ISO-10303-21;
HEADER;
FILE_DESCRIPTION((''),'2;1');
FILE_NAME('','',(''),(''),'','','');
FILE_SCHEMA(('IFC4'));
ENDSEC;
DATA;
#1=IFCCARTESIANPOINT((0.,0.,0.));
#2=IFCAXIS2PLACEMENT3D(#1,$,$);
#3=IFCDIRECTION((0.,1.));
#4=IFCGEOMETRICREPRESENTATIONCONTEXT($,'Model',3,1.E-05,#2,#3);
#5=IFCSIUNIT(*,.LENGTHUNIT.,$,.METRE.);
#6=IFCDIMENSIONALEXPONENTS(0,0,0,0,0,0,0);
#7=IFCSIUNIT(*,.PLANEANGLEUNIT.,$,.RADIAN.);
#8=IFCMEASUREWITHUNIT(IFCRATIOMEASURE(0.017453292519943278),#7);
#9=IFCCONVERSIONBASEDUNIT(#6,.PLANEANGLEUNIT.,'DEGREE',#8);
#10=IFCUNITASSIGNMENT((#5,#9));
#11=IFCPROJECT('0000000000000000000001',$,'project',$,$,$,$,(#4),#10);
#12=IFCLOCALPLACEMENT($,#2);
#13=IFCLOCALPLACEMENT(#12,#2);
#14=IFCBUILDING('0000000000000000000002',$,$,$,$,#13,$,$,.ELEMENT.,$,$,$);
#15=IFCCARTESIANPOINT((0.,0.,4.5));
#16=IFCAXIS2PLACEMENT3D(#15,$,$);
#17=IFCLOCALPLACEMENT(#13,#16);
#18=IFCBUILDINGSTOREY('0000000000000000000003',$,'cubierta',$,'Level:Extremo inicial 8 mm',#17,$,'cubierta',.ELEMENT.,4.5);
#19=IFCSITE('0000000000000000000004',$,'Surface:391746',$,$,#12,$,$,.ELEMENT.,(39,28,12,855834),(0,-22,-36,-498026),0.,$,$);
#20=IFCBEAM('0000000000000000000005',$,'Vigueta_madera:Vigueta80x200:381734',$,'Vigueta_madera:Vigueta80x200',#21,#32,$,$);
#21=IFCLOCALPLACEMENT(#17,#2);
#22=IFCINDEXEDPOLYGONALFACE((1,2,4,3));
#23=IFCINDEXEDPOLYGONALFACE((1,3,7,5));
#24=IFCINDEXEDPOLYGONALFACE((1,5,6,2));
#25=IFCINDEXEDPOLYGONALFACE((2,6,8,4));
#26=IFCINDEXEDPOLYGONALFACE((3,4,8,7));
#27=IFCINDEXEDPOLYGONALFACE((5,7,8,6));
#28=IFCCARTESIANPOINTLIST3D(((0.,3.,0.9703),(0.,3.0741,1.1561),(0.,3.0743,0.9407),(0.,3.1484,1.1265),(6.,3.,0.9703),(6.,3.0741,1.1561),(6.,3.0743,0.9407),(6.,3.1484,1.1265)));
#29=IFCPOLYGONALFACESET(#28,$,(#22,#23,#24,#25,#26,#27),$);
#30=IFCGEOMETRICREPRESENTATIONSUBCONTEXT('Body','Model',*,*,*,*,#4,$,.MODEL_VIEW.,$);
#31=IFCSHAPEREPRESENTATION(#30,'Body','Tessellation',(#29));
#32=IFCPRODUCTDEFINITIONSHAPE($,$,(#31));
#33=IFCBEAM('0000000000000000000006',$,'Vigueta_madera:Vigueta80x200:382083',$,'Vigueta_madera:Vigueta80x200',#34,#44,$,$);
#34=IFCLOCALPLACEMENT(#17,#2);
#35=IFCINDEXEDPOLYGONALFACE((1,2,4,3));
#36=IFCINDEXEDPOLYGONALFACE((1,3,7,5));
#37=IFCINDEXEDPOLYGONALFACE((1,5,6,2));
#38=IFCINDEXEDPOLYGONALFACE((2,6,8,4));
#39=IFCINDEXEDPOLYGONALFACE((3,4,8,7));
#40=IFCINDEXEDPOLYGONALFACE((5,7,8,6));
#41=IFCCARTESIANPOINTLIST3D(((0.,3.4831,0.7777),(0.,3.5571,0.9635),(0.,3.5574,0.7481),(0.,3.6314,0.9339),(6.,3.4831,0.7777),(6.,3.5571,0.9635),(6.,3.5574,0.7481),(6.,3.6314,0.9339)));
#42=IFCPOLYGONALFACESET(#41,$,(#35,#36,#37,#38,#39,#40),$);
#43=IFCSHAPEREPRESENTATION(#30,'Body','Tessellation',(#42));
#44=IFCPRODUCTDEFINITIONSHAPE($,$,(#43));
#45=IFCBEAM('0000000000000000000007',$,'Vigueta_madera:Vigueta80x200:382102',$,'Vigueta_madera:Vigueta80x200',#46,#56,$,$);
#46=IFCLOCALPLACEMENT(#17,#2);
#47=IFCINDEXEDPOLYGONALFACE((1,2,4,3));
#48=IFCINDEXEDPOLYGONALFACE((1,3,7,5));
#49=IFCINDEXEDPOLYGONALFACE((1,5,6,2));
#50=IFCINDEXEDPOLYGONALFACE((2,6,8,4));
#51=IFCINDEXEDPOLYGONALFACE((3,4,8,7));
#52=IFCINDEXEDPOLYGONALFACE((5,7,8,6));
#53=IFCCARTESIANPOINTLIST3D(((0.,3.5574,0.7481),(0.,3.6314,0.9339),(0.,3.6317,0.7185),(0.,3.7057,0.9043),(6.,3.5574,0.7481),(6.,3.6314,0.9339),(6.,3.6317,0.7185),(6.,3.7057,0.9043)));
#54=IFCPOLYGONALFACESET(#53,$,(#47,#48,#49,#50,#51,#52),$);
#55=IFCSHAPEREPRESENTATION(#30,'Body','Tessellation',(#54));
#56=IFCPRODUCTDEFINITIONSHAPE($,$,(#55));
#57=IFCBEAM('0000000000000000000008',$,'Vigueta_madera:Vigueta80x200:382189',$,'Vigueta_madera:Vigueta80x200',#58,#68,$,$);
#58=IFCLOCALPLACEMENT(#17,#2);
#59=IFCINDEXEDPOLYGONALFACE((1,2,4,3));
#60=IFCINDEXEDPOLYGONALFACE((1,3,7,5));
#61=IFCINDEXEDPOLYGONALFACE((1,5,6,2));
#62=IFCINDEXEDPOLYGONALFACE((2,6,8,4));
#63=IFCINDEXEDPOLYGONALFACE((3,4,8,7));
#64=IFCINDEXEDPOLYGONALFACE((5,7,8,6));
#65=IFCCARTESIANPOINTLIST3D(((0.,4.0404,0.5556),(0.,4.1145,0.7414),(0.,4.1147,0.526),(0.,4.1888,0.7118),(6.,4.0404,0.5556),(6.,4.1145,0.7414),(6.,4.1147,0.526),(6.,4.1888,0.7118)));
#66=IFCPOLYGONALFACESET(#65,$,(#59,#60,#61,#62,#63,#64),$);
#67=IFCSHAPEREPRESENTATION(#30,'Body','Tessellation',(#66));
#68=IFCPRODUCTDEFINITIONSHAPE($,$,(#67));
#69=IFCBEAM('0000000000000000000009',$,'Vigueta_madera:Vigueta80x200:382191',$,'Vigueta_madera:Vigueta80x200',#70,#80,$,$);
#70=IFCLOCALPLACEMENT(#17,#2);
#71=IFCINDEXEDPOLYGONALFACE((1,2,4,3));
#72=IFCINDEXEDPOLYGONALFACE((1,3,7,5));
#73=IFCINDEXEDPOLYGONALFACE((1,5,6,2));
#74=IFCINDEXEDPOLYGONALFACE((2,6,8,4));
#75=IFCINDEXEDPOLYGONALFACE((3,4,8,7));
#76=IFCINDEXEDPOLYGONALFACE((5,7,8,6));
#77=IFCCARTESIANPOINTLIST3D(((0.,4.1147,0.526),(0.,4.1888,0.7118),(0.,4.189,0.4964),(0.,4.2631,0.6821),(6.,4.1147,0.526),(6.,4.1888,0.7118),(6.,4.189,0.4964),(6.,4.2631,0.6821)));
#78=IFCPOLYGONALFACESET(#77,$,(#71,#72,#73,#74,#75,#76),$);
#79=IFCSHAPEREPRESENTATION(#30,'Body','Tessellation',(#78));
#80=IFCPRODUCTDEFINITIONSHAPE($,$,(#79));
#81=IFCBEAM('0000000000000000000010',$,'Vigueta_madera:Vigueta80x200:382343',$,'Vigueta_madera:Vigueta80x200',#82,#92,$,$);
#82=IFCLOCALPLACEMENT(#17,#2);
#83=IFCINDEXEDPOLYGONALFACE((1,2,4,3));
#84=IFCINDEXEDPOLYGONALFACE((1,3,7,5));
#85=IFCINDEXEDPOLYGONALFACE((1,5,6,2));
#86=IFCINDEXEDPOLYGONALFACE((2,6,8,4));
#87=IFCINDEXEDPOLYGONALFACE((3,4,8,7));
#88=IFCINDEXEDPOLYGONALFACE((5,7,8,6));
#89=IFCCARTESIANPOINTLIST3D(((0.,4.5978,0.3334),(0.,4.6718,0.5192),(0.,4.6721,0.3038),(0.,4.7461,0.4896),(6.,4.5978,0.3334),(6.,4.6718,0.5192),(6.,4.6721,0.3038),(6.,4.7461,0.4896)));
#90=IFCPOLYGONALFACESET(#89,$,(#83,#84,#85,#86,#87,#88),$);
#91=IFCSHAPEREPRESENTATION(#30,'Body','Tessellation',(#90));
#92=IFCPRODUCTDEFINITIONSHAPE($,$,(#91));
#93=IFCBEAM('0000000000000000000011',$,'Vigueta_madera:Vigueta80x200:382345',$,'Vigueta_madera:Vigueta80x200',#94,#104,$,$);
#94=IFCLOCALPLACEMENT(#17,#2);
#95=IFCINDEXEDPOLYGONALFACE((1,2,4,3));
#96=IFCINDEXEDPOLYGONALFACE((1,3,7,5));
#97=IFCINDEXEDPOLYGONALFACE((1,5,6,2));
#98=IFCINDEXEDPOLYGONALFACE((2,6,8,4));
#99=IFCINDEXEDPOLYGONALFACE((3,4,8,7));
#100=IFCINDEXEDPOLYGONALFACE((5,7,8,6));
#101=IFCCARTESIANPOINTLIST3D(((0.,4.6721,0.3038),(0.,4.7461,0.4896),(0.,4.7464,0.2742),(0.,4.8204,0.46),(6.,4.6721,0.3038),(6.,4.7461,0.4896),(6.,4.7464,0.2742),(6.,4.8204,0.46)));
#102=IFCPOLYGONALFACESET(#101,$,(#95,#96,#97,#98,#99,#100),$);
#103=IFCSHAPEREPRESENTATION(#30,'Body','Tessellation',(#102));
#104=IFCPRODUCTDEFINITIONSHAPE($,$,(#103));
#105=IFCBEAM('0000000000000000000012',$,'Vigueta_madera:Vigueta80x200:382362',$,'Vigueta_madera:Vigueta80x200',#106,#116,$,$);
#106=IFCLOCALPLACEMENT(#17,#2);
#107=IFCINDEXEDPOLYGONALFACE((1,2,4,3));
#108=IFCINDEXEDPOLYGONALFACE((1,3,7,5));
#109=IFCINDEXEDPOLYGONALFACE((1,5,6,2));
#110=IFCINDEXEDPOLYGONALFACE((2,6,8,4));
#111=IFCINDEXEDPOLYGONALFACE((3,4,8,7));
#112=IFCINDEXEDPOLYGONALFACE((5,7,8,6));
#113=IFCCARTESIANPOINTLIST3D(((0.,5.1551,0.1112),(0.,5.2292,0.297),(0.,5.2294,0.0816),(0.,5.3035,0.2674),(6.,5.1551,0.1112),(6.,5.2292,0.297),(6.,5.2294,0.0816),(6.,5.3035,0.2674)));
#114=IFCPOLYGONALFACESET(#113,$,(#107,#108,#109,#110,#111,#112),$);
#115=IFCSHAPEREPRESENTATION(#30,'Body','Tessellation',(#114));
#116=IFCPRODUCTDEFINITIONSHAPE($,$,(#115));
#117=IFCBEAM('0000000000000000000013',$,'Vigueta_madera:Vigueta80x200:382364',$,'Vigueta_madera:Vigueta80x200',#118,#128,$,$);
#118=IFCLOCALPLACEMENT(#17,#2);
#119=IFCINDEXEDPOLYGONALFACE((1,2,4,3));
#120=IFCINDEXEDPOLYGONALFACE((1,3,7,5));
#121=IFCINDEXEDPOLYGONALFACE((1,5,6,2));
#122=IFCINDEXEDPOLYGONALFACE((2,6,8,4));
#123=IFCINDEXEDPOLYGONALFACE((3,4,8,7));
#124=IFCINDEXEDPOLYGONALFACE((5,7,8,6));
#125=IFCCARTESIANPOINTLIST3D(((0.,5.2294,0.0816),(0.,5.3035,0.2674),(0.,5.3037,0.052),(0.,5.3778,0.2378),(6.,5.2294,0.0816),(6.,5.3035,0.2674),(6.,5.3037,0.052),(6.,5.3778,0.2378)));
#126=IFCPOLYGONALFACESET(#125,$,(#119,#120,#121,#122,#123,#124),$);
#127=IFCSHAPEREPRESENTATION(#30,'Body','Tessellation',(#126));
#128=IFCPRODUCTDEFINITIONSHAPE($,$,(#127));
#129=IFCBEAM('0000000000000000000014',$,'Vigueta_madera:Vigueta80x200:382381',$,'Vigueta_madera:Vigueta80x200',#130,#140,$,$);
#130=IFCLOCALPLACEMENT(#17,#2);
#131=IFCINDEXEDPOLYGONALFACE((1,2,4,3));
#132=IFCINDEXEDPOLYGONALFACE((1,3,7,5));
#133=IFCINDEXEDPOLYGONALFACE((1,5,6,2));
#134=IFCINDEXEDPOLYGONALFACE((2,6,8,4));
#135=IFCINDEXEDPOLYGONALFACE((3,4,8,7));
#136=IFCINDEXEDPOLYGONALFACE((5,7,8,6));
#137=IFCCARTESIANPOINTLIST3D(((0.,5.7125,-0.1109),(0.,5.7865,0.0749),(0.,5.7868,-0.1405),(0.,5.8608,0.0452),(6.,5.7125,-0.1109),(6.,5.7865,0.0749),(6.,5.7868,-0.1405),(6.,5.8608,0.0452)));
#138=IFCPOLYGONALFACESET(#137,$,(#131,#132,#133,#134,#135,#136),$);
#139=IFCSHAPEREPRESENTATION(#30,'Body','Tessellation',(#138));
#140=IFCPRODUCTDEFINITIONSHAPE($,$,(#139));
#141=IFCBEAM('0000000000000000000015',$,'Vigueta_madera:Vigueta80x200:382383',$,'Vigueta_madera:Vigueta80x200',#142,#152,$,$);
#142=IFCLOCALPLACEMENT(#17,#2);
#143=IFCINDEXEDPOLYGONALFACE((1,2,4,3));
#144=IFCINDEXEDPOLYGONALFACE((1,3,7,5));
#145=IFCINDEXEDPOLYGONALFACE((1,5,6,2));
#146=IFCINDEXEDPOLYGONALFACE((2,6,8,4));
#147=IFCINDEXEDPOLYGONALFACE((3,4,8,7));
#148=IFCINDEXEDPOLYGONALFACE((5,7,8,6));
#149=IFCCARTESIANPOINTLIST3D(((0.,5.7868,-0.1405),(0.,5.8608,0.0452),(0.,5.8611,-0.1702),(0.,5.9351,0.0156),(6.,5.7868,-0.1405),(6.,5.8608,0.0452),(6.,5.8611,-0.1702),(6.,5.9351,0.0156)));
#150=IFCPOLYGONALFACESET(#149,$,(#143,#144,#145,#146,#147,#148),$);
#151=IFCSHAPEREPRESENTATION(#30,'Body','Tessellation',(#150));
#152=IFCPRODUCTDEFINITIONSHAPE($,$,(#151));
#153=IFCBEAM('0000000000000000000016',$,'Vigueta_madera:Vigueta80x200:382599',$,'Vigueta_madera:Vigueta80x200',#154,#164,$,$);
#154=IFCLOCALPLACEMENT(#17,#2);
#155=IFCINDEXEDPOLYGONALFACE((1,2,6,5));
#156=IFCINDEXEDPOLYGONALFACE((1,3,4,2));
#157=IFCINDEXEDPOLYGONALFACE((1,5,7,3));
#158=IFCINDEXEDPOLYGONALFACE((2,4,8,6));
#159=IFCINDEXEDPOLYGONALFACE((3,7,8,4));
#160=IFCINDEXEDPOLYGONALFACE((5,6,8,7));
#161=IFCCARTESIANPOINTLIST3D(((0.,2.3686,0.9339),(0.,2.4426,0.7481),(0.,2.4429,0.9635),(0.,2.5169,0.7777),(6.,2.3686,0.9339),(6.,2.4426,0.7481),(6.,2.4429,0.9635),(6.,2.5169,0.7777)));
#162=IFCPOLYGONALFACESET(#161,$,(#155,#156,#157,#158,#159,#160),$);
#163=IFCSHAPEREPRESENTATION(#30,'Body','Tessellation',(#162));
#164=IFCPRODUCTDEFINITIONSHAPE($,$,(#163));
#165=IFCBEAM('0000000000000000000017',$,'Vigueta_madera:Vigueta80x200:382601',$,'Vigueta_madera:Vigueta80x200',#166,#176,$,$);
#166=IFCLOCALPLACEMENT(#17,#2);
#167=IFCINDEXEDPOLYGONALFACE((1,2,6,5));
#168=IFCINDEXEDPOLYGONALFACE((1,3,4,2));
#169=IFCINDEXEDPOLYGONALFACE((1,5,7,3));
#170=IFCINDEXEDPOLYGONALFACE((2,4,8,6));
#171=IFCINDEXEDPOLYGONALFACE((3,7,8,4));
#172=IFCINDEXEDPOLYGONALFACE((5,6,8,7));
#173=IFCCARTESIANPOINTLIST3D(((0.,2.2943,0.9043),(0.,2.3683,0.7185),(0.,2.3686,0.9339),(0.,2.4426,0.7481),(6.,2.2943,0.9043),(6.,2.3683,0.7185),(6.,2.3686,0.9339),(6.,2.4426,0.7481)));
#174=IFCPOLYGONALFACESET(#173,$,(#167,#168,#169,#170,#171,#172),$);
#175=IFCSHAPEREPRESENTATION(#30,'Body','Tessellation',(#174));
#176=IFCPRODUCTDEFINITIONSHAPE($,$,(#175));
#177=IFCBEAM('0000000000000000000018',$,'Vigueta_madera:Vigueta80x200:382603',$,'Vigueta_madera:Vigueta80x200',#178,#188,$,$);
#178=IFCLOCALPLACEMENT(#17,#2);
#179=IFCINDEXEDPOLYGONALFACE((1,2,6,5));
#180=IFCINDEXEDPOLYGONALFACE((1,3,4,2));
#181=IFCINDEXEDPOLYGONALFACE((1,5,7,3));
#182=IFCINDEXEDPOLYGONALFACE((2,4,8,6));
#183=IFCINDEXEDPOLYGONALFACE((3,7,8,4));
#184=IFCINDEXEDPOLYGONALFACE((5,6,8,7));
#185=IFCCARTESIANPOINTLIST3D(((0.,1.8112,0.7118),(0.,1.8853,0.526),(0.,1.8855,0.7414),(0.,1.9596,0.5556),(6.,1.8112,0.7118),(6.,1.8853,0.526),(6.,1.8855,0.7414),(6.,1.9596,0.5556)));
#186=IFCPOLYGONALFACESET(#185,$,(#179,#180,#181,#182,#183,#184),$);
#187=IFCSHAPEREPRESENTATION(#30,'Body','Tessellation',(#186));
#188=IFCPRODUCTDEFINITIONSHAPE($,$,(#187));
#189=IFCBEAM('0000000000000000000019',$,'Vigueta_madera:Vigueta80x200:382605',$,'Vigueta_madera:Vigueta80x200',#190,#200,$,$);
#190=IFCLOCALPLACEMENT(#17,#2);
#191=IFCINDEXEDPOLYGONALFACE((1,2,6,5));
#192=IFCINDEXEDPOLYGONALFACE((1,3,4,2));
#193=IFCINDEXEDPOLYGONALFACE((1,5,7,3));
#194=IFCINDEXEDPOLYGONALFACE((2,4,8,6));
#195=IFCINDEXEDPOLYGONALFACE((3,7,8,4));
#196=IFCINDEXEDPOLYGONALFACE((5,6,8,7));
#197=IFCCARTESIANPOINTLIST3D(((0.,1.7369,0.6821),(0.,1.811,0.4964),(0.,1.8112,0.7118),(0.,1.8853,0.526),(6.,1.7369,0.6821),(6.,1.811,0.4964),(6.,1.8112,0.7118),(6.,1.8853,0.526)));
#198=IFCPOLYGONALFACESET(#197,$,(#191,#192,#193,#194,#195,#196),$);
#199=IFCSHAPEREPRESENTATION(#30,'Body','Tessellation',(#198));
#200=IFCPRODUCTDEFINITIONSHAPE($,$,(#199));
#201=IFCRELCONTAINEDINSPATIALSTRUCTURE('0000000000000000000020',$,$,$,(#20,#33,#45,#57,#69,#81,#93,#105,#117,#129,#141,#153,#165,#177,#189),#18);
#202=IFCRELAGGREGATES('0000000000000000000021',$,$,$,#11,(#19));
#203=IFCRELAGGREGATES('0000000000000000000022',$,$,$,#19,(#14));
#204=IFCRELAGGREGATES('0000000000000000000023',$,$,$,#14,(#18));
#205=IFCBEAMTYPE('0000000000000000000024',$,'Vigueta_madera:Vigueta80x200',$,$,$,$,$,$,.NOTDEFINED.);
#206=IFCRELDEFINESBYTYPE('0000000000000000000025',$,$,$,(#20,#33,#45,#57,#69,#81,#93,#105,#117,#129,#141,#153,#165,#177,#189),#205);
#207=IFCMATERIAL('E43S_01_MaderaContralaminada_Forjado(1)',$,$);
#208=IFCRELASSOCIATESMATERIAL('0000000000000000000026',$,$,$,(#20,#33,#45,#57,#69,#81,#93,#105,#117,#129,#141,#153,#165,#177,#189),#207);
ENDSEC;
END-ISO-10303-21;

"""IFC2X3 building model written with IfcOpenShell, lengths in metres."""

from ifc_helpers import new_model, entity, si_unit, converted_unit, direction, frame, frame_2d, origin, place, context, subcontext, project, spatial, rectangle, extrude, material, type_object, element, save


model = new_model("IFC2X3")

# Units and contexts
model_context = context("Model", 3, precision=1e-05, world=origin(), true_north=direction((0.0, 1.0)))
body_context = subcontext(model_context, "Body", "Model", "MODEL_VIEW")
ifc_project = project(units=[si_unit("LENGTHUNIT", "METRE"), converted_unit("PLANEANGLEUNIT", "DEGREE", entity("IfcRatioMeasure", 0.017453292519943278), si_unit("PLANEANGLEUNIT", "RADIAN"), dimensions=[0, 0, 0, 0, 0, 0, 0])], contexts=[model_context])

# Site, building, storey
site_placement = place(None, origin())
site = spatial("IfcSite", under=ifc_project, at=site_placement, Name="Surface:391746", CompositionType="ELEMENT", RefLatitude=(39, 28, 12, 855834), RefLongitude=(0, -22, -36, -498026), RefElevation=0.0)
building_placement = place(site_placement, origin())
building = spatial("IfcBuilding", under=site, at=building_placement, CompositionType="ELEMENT")
storey_placement = place(building_placement, frame((0.0, 0.0, 4.5)))
storey = spatial("IfcBuildingStorey", under=building, at=storey_placement, Name="cubierta", ObjectType="Level:Extremo inicial 8 mm", LongName="cubierta", CompositionType="ELEMENT", Elevation=4.5)

# Beams
ifc_material = material(Name="E43S_01_MaderaContralaminada_Forjado(1)")
beam_type = type_object("IfcBeamType", Name="Vigueta_madera:Vigueta80x200", PredefinedType="NOTDEFINED")
beam_1_placement = place(storey_placement, frame((0.0, 3.1112, 1.1413)))
element("IfcBeam", 1, at=beam_1_placement, inside=storey, type_object=beam_type, material=ifc_material, Name="Vigueta_madera:Vigueta80x200:381734", ObjectType="Vigueta_madera:Vigueta80x200", context=body_context, shape_type="SweptSolid", body=[
    extrude(rectangle(XDim=0.2, YDim=0.08, at=frame_2d((0.0, 0.0), x_axis=(0.0, 1.0))), frame((0.0, -0.037, -0.0929), z_axis=(1.0, 0.0, 0.0), x_axis=(0.0, -0.928939, 0.370233)), (0.0, 0.0, 1.0), 6.0),
])
beam_2_placement = place(storey_placement, frame((0.0, 3.5943, 0.9487)))
element("IfcBeam", 2, at=beam_2_placement, inside=storey, type_object=beam_type, material=ifc_material, Name="Vigueta_madera:Vigueta80x200:382083", ObjectType="Vigueta_madera:Vigueta80x200", context=body_context, shape_type="SweptSolid", body=[
    extrude(rectangle(XDim=0.2, YDim=0.08, at=frame_2d((0.0, 0.0), x_axis=(0.0, 1.0))), frame((0.0, -0.037, -0.0929), z_axis=(1.0, 0.0, 0.0), x_axis=(0.0, -0.928939, 0.370233)), (0.0, 0.0, 1.0), 6.0),
])
for number, where, name in (
    (3, (0.0, 3.6686, 0.9191), "Vigueta_madera:Vigueta80x200:382102"),
    (4, (0.0, 4.1516, 0.7266), "Vigueta_madera:Vigueta80x200:382189"),
):
    element("IfcBeam", number, at=place(storey_placement, frame(where)), inside=storey, type_object=beam_type, material=ifc_material, Name=name, ObjectType="Vigueta_madera:Vigueta80x200", context=body_context, shape_type="SweptSolid", body=[
        extrude(rectangle(XDim=0.2, YDim=0.08, at=frame_2d((0.0, 0.0), x_axis=(0.0, 1.0))), frame((0.0, -0.037, -0.0929), z_axis=(1.0, 0.0, 0.0), x_axis=(0.0, -0.928939, 0.370233)), (0.0, 0.0, 1.0), 6.0),
    ])
beam_3_placement = place(storey_placement, frame((0.0, 4.2259, 0.697)))
element("IfcBeam", 5, at=beam_3_placement, inside=storey, type_object=beam_type, material=ifc_material, Name="Vigueta_madera:Vigueta80x200:382191", ObjectType="Vigueta_madera:Vigueta80x200", context=body_context, shape_type="SweptSolid", body=[
    extrude(rectangle(XDim=0.2, YDim=0.08, at=frame_2d((0.0, 0.0), x_axis=(0.0, 1.0))), frame((0.0, -0.037, -0.0929), z_axis=(1.0, 0.0, 0.0), x_axis=(0.0, -0.928939, 0.370233)), (0.0, 0.0, 1.0), 6.0),
])
for number, where, name in (
    (6, (0.0, 4.709, 0.5044), "Vigueta_madera:Vigueta80x200:382343"),
    (7, (0.0, 4.7833, 0.4748), "Vigueta_madera:Vigueta80x200:382345"),
):
    element("IfcBeam", number, at=place(storey_placement, frame(where)), inside=storey, type_object=beam_type, material=ifc_material, Name=name, ObjectType="Vigueta_madera:Vigueta80x200", context=body_context, shape_type="SweptSolid", body=[
        extrude(rectangle(XDim=0.2, YDim=0.08, at=frame_2d((0.0, 0.0), x_axis=(0.0, 1.0))), frame((0.0, -0.037, -0.0929), z_axis=(1.0, 0.0, 0.0), x_axis=(0.0, -0.928939, 0.370233)), (0.0, 0.0, 1.0), 6.0),
    ])
beam_4_placement = place(storey_placement, frame((0.0, 5.2663, 0.2822)))
element("IfcBeam", 8, at=beam_4_placement, inside=storey, type_object=beam_type, material=ifc_material, Name="Vigueta_madera:Vigueta80x200:382362", ObjectType="Vigueta_madera:Vigueta80x200", context=body_context, shape_type="SweptSolid", body=[
    extrude(rectangle(XDim=0.2, YDim=0.08, at=frame_2d((0.0, 0.0), x_axis=(0.0, 1.0))), frame((0.0, -0.037, -0.0929), z_axis=(1.0, 0.0, 0.0), x_axis=(0.0, -0.928939, 0.370233)), (0.0, 0.0, 1.0), 6.0),
])
for number, where, name in (
    (9, (0.0, 5.3406, 0.2526), "Vigueta_madera:Vigueta80x200:382364"),
    (10, (0.0, 5.8237, 0.0601), "Vigueta_madera:Vigueta80x200:382381"),
):
    element("IfcBeam", number, at=place(storey_placement, frame(where)), inside=storey, type_object=beam_type, material=ifc_material, Name=name, ObjectType="Vigueta_madera:Vigueta80x200", context=body_context, shape_type="SweptSolid", body=[
        extrude(rectangle(XDim=0.2, YDim=0.08, at=frame_2d((0.0, 0.0), x_axis=(0.0, 1.0))), frame((0.0, -0.037, -0.0929), z_axis=(1.0, 0.0, 0.0), x_axis=(0.0, -0.928939, 0.370233)), (0.0, 0.0, 1.0), 6.0),
    ])
beam_5_placement = place(storey_placement, frame((0.0, 5.898, 0.0304)))
element("IfcBeam", 11, at=beam_5_placement, inside=storey, type_object=beam_type, material=ifc_material, Name="Vigueta_madera:Vigueta80x200:382383", ObjectType="Vigueta_madera:Vigueta80x200", context=body_context, shape_type="SweptSolid", body=[
    extrude(rectangle(XDim=0.2, YDim=0.08, at=frame_2d((0.0, 0.0), x_axis=(0.0, 1.0))), frame((0.0, -0.037, -0.0929), z_axis=(1.0, 0.0, 0.0), x_axis=(0.0, -0.928939, 0.370233)), (0.0, 0.0, 1.0), 6.0),
])
beam_6_placement = place(storey_placement, frame((0.0, 2.4057, 0.9487)))
element("IfcBeam", 12, at=beam_6_placement, inside=storey, type_object=beam_type, material=ifc_material, Name="Vigueta_madera:Vigueta80x200:382599", ObjectType="Vigueta_madera:Vigueta80x200", context=body_context, shape_type="SweptSolid", body=[
    extrude(rectangle(XDim=0.2, YDim=0.08, at=frame_2d((0.0, 0.0), x_axis=(1.0, 0.0))), frame((0.0, 0.037, -0.0929), z_axis=(1.0, 0.0, 0.0), x_axis=(0.0, -0.370233, 0.928939)), (0.0, 0.0, 1.0), 6.0),
])
beam_7_placement = place(storey_placement, frame((0.0, 2.3314, 0.9191)))
element("IfcBeam", 13, at=beam_7_placement, inside=storey, type_object=beam_type, material=ifc_material, Name="Vigueta_madera:Vigueta80x200:382601", ObjectType="Vigueta_madera:Vigueta80x200", context=body_context, shape_type="SweptSolid", body=[
    extrude(rectangle(XDim=0.2, YDim=0.08, at=frame_2d((0.0, 0.0), x_axis=(1.0, 0.0))), frame((0.0, 0.037, -0.0929), z_axis=(1.0, 0.0, 0.0), x_axis=(0.0, -0.370233, 0.928939)), (0.0, 0.0, 1.0), 6.0),
])
beam_8_placement = place(storey_placement, frame((0.0, 1.8484, 0.7266)))
element("IfcBeam", 14, at=beam_8_placement, inside=storey, type_object=beam_type, material=ifc_material, Name="Vigueta_madera:Vigueta80x200:382603", ObjectType="Vigueta_madera:Vigueta80x200", context=body_context, shape_type="SweptSolid", body=[
    extrude(rectangle(XDim=0.2, YDim=0.08, at=frame_2d((0.0, 0.0), x_axis=(1.0, 0.0))), frame((0.0, 0.037, -0.0929), z_axis=(1.0, 0.0, 0.0), x_axis=(0.0, -0.370233, 0.928939)), (0.0, 0.0, 1.0), 6.0),
])
beam_9_placement = place(storey_placement, frame((0.0, 1.7741, 0.697)))
element("IfcBeam", 15, at=beam_9_placement, inside=storey, type_object=beam_type, material=ifc_material, Name="Vigueta_madera:Vigueta80x200:382605", ObjectType="Vigueta_madera:Vigueta80x200", context=body_context, shape_type="SweptSolid", body=[
    extrude(rectangle(XDim=0.2, YDim=0.08, at=frame_2d((0.0, 0.0), x_axis=(1.0, 0.0))), frame((0.0, 0.037, -0.0929), z_axis=(1.0, 0.0, 0.0), x_axis=(0.0, -0.370233, 0.928939)), (0.0, 0.0, 1.0), 6.0),
])

save(model, "model.ifc")
